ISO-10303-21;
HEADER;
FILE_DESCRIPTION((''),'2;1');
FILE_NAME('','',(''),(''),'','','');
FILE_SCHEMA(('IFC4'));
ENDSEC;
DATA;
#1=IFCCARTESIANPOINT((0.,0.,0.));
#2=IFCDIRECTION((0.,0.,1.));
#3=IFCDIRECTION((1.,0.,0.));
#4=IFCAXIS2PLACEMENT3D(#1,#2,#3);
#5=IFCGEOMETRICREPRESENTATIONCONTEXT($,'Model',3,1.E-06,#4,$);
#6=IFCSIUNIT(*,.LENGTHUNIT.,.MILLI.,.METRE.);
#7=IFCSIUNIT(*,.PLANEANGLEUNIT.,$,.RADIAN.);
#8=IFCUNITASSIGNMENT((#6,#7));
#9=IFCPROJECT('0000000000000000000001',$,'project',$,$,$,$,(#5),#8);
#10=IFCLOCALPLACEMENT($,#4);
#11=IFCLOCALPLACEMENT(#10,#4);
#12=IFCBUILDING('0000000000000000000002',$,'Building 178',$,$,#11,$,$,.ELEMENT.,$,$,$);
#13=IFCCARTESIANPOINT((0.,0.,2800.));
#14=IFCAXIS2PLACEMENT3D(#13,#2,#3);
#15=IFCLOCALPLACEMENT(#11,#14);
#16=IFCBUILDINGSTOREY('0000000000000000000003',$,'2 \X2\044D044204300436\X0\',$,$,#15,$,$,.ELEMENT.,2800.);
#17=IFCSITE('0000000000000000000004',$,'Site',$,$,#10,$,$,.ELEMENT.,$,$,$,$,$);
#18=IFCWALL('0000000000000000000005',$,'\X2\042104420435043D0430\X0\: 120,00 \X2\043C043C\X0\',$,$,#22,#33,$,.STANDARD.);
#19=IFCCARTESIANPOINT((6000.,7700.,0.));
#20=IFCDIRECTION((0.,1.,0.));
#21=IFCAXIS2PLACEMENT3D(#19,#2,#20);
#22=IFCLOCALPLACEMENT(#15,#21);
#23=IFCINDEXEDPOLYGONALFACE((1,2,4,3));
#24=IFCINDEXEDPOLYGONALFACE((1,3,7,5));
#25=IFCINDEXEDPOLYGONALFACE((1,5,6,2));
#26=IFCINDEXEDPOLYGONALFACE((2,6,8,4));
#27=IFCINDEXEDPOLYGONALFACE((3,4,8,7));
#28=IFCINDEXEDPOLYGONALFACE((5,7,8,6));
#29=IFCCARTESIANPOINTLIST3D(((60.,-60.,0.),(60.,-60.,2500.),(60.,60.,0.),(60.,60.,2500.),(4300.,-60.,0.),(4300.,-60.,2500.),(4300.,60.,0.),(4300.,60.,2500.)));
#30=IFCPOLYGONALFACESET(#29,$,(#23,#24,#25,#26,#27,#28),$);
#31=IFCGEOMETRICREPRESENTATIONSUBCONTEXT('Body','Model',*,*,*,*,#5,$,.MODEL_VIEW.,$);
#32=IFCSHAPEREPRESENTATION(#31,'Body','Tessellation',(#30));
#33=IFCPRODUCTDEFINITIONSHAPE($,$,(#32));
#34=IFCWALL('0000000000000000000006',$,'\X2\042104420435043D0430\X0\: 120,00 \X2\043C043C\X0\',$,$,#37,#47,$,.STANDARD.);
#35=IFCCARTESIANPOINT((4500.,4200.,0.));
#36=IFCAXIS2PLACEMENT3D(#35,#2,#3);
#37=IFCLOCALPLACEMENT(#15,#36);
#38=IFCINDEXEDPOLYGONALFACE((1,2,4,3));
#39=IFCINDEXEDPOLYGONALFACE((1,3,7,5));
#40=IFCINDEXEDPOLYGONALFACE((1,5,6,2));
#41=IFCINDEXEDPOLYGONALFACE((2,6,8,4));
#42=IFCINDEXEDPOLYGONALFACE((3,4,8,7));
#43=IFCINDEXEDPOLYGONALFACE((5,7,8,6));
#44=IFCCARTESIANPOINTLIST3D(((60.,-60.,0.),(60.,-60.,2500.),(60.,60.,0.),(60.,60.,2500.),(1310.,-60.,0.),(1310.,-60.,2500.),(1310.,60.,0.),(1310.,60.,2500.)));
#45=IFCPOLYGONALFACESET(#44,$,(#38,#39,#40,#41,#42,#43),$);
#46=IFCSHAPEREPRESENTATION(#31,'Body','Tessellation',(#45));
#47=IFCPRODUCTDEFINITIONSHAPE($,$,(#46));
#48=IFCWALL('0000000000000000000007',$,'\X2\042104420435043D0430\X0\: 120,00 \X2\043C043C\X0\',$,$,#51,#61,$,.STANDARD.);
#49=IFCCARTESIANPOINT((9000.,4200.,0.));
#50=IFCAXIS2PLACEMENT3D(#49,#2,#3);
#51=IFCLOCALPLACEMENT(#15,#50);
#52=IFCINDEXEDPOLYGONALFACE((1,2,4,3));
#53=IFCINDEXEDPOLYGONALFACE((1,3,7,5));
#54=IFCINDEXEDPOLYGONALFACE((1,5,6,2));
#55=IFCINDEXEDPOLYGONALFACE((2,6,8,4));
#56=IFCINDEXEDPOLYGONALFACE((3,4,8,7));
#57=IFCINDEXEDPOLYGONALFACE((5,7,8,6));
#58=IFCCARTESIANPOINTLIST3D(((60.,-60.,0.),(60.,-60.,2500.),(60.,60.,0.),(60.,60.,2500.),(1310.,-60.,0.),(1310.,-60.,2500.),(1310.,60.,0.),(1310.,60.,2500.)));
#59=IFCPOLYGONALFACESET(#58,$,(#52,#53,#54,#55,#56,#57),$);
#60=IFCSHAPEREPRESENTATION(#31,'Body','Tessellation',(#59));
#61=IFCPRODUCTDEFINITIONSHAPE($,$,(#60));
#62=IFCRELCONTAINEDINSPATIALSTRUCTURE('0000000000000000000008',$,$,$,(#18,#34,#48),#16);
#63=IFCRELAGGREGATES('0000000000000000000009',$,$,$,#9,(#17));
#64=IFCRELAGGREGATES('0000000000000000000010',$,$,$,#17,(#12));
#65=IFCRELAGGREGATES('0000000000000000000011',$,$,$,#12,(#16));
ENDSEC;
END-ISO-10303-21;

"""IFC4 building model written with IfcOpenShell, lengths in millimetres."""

from ifc_helpers import new_model, si_unit, frame, origin_with_axes, place, context, subcontext, project, spatial, line, indexed_curve, outline, extrude, source, transform, mapped, element, save


model = new_model("IFC4")

# Units and contexts
model_context = context("Model", 3, precision=1e-06, world=origin_with_axes())
body_context = subcontext(model_context, "Body", "Model", "MODEL_VIEW")
ifc_project = project(units=[si_unit("LENGTHUNIT", "METRE", prefix="MILLI"), si_unit("PLANEANGLEUNIT", "RADIAN")], contexts=[model_context])

# Site, building, storey
site_placement = place(None, origin_with_axes())
site = spatial("IfcSite", under=ifc_project, at=site_placement, Name="Site", CompositionType="ELEMENT")
building_placement = place(site_placement, origin_with_axes())
building = spatial("IfcBuilding", under=site, at=building_placement, Name="Building 178", CompositionType="ELEMENT")
storey_placement = place(building_placement, frame((0.0, 0.0, 2800.0), z_axis=(0.0, 0.0, 1.0), x_axis=(1.0, 0.0, 0.0)))
storey = spatial("IfcBuildingStorey", under=building, at=storey_placement, Name="2 этаж", CompositionType="ELEMENT", Elevation=2800.0)

# Walls
shared_shape_1 = source(origin_with_axes(), body_context, "Body", "SweptSolid", [
    extrude(outline(indexed_curve([(60.0, -60.0), (4300.0, -60.0), (4300.0, 60.0), (60.0, 60.0)], segments=[line(1, 2), line(2, 3), line(3, 4), line(4, 1)])), origin_with_axes(), (0.0, 0.0, 1.0), 2500.0),
])
wall_1_placement = place(storey_placement, frame((6000.0, 7700.0, 0.0), z_axis=(0.0, 0.0, 1.0), x_axis=(0.0, 1.0, 0.0)))
element("IfcWall", 1, at=wall_1_placement, inside=storey, Name="Стена: 120,00 мм", PredefinedType="STANDARD", context=body_context, shape_type="MappedRepresentation", body=[
    mapped(shared_shape_1, transform((0.0, 0.0, 0.0), x_axis=(1.0, 0.0, 0.0), y_axis=(0.0, 1.0, 0.0), z_axis=(0.0, 0.0, 1.0), scale=1.0)),
])
shared_shape_2 = source(origin_with_axes(), body_context, "Body", "SweptSolid", [
    extrude(outline(indexed_curve([(60.0, -60.0), (1310.0, -60.0), (1310.0, 60.0), (60.0, 60.0)], segments=[line(1, 2), line(2, 3), line(3, 4), line(4, 1)])), origin_with_axes(), (0.0, 0.0, 1.0), 2500.0),
])
for number, where, z_axis, x_axis, name in (
    (2, (4500.0, 4200.0, 0.0), (0.0, 0.0, 1.0), (1.0, 0.0, 0.0), "Стена: 120,00 мм"),
    (3, (9000.0, 4200.0, 0.0), (0.0, 0.0, 1.0), (1.0, 0.0, 0.0), "Стена: 120,00 мм"),
):
    element("IfcWall", number, at=place(storey_placement, frame(where, z_axis=z_axis, x_axis=x_axis)), inside=storey, Name=name, PredefinedType="STANDARD", context=body_context, shape_type="MappedRepresentation", body=[
        mapped(shared_shape_2, transform((0.0, 0.0, 0.0), x_axis=(1.0, 0.0, 0.0), y_axis=(0.0, 1.0, 0.0), z_axis=(0.0, 0.0, 1.0), scale=1.0)),
    ])

save(model, "model.ifc")
